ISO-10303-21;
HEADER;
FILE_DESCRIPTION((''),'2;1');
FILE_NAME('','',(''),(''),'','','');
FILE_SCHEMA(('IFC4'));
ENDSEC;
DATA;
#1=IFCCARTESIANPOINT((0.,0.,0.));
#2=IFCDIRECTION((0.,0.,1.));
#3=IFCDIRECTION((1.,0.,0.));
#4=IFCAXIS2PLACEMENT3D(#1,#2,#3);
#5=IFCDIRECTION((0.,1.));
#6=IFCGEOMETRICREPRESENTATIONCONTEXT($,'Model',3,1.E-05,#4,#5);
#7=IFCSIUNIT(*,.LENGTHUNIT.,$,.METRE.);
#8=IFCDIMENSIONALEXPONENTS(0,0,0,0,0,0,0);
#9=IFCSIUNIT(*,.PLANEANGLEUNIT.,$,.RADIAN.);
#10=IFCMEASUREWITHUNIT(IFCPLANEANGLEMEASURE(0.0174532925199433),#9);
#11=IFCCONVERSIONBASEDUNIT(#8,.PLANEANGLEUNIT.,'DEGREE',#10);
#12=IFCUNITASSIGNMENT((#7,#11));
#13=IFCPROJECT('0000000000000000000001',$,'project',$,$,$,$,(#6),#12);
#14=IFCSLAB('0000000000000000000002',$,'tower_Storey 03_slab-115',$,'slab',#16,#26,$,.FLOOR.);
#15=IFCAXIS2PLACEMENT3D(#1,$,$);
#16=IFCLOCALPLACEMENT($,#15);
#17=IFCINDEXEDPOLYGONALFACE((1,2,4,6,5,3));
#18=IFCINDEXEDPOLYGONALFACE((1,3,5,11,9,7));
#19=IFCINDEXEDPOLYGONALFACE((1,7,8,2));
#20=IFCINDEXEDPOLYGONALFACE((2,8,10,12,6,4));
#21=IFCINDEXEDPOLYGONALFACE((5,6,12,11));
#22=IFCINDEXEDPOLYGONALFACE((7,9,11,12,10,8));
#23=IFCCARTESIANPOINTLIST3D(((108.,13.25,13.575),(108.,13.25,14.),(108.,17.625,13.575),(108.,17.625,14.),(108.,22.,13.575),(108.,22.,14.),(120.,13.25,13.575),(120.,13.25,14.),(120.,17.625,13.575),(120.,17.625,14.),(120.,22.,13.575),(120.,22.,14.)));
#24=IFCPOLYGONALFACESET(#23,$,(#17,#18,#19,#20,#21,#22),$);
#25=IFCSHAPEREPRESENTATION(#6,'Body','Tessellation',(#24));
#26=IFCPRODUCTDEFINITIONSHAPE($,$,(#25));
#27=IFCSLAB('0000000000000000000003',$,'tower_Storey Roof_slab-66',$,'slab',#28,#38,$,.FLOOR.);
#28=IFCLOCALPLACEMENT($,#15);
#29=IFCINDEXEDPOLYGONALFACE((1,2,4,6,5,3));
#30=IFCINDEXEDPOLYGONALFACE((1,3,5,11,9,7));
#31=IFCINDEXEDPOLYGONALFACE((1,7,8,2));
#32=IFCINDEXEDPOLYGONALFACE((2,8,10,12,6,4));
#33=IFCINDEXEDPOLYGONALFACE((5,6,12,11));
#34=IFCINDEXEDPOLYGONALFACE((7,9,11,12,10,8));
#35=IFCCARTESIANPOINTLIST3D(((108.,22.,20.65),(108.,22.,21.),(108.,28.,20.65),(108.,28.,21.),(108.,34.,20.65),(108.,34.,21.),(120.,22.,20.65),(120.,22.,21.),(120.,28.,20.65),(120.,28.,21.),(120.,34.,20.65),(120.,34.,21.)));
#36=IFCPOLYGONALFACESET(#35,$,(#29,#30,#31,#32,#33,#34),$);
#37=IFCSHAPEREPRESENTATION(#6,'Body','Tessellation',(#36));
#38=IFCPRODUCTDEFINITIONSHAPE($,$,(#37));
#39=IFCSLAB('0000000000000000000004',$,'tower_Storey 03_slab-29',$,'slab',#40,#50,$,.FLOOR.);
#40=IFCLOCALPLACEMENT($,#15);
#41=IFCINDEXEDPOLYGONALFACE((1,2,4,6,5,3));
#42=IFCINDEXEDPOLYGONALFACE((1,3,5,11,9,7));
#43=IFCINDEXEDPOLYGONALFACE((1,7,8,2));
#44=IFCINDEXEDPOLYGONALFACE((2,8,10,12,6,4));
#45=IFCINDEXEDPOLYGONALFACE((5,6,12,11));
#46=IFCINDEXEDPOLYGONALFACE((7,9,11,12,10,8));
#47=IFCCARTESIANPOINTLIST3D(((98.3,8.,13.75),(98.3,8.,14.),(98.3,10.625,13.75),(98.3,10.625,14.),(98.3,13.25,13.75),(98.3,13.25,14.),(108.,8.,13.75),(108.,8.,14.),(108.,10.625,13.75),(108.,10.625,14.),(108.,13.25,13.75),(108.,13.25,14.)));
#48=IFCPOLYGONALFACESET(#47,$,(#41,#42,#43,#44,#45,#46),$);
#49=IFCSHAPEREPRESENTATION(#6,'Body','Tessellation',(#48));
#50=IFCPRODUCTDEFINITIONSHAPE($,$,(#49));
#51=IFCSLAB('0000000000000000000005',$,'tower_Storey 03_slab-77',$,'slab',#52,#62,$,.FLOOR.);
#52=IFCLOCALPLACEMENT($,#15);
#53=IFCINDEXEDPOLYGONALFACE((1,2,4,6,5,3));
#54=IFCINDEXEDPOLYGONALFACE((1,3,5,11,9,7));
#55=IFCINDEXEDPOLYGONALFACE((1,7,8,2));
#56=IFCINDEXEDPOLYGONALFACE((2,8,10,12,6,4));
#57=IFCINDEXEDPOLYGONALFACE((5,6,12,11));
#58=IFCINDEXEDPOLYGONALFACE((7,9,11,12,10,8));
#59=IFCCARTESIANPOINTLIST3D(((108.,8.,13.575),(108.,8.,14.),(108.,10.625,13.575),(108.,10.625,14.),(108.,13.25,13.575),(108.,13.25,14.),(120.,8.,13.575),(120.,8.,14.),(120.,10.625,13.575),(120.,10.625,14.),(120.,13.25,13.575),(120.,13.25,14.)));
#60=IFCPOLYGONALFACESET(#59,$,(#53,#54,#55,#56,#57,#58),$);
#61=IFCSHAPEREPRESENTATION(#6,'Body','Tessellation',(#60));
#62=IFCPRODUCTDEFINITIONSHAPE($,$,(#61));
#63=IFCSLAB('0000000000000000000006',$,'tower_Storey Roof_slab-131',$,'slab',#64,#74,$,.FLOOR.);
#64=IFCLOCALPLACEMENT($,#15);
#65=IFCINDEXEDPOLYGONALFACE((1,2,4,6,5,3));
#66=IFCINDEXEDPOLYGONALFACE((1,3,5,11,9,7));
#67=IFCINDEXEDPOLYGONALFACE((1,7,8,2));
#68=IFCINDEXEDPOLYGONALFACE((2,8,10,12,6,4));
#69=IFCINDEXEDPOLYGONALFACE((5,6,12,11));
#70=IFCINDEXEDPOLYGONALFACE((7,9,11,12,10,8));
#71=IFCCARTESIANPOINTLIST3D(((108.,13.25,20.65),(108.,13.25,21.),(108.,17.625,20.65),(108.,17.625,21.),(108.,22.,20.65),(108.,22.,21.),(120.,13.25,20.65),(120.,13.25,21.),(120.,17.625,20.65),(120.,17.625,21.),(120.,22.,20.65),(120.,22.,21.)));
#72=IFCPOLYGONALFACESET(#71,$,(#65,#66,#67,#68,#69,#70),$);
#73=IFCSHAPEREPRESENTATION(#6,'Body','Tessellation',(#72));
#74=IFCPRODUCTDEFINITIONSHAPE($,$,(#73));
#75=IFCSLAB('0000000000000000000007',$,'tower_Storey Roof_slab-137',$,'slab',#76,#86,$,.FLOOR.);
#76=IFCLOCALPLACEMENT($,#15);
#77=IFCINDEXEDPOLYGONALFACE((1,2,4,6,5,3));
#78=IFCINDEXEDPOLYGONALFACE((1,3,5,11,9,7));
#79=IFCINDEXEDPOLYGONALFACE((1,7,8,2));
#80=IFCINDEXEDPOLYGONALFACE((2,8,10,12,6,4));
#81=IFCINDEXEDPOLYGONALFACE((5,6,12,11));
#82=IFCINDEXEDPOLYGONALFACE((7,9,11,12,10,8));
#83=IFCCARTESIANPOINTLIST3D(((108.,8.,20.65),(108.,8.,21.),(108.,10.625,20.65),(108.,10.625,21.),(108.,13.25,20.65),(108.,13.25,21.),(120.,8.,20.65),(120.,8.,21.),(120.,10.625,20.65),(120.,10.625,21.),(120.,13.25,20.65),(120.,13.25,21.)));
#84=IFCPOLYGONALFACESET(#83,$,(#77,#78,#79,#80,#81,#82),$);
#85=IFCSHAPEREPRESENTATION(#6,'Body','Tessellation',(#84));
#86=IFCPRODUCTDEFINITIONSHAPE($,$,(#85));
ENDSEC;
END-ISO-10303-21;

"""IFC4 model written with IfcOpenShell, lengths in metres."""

from ifc_helpers import new_model, entity, si_unit, converted_unit, direction, frame, origin_with_axes, place, context, project, polyline, outline, extrude, element, save


model = new_model("IFC4")

# Units and contexts
model_context = context("Model", 3, precision=1e-05, world=origin_with_axes(), true_north=direction((0.0, 1.0)))
ifc_project = project(units=[si_unit("LENGTHUNIT", "METRE"), converted_unit("PLANEANGLEUNIT", "DEGREE", entity("IfcPlaneAngleMeasure", 0.0174532925199433), si_unit("PLANEANGLEUNIT", "RADIAN"), dimensions=[0, 0, 0, 0, 0, 0, 0])], contexts=[model_context])

# Shared definitions
placement_1 = place(None, origin_with_axes())
placement_2 = place(placement_1, frame((0.0, 0.0, 14.0), z_axis=(0.0, 0.0, 1.0), x_axis=(1.0, 0.0, 0.0)))

# Shared definitions
placement_3 = place(placement_1, frame((0.0, 0.0, 21.0), z_axis=(0.0, 0.0, 1.0), x_axis=(1.0, 0.0, 0.0)))

# Slabs
slab_1_placement = place(placement_2, frame((114.0, 17.625, -0.425), z_axis=(0.0, 0.0, 1.0), x_axis=(1.0, 0.0, 0.0)))
element("IfcSlab", 1, at=slab_1_placement, Name="tower_Storey 03_slab-115", ObjectType="slab", PredefinedType="FLOOR", context=model_context, body=[
    extrude(outline(polyline([(-6.0, 0.0, 0.0), (-6.0, -4.375, 0.0), (6.0, -4.375, 0.0), (6.0, 0.0, 0.0), (6.0, 4.375, 0.0), (-6.0, 4.375, 0.0), (-6.0, 0.0, 0.0)])), origin_with_axes(), (0.0, 0.0, 1.0), 0.425),
])
slab_2_placement = place(placement_3, frame((114.0, 28.0, -0.35), z_axis=(0.0, 0.0, 1.0), x_axis=(1.0, 0.0, 0.0)))
element("IfcSlab", 2, at=slab_2_placement, Name="tower_Storey Roof_slab-66", ObjectType="slab", PredefinedType="FLOOR", context=model_context, body=[
    extrude(outline(polyline([(-6.0, -6.0, 0.0), (6.0, -6.0, 0.0), (6.0, 0.0, 0.0), (6.0, 6.0, 0.0), (-6.0, 6.0, 0.0), (-6.0, 0.0, 0.0), (-6.0, -6.0, 0.0)])), origin_with_axes(), (0.0, 0.0, 1.0), 0.35),
])
slab_3_placement = place(placement_2, frame((103.15, 10.625, -0.25), z_axis=(0.0, 0.0, 1.0), x_axis=(1.0, 0.0, 0.0)))
element("IfcSlab", 3, at=slab_3_placement, Name="tower_Storey 03_slab-29", ObjectType="slab", PredefinedType="FLOOR", context=model_context, body=[
    extrude(outline(polyline([(-4.85, -2.625, 0.0), (4.85, -2.625, 0.0), (4.85, 0.0, 0.0), (4.85, 2.625, 0.0), (-4.85, 2.625, 0.0), (-4.85, 0.0, 0.0), (-4.85, -2.625, 0.0)])), origin_with_axes(), (0.0, 0.0, 1.0), 0.25),
])
slab_4_placement = place(placement_2, frame((114.0, 10.625, -0.425), z_axis=(0.0, 0.0, 1.0), x_axis=(1.0, 0.0, 0.0)))
element("IfcSlab", 4, at=slab_4_placement, Name="tower_Storey 03_slab-77", ObjectType="slab", PredefinedType="FLOOR", context=model_context, body=[
    extrude(outline(polyline([(-6.0, -2.625, 0.0), (6.0, -2.625, 0.0), (6.0, 0.0, 0.0), (6.0, 2.625, 0.0), (-6.0, 2.625, 0.0), (-6.0, 0.0, 0.0), (-6.0, -2.625, 0.0)])), origin_with_axes(), (0.0, 0.0, 1.0), 0.425),
])
slab_5_placement = place(placement_3, frame((114.0, 17.625, -0.35), z_axis=(0.0, 0.0, 1.0), x_axis=(1.0, 0.0, 0.0)))
element("IfcSlab", 5, at=slab_5_placement, Name="tower_Storey Roof_slab-131", ObjectType="slab", PredefinedType="FLOOR", context=model_context, body=[
    extrude(outline(polyline([(-6.0, 0.0, 0.0), (-6.0, -4.375, 0.0), (6.0, -4.375, 0.0), (6.0, 0.0, 0.0), (6.0, 4.375, 0.0), (-6.0, 4.375, 0.0), (-6.0, 0.0, 0.0)])), origin_with_axes(), (0.0, 0.0, 1.0), 0.35),
])
slab_6_placement = place(placement_3, frame((114.0, 10.625, -0.35), z_axis=(0.0, 0.0, 1.0), x_axis=(1.0, 0.0, 0.0)))
element("IfcSlab", 6, at=slab_6_placement, Name="tower_Storey Roof_slab-137", ObjectType="slab", PredefinedType="FLOOR", context=model_context, body=[
    extrude(outline(polyline([(-6.0, -2.625, 0.0), (6.0, -2.625, 0.0), (6.0, 0.0, 0.0), (6.0, 2.625, 0.0), (-6.0, 2.625, 0.0), (-6.0, 0.0, 0.0), (-6.0, -2.625, 0.0)])), origin_with_axes(), (0.0, 0.0, 1.0), 0.35),
])

save(model, "model.ifc")
